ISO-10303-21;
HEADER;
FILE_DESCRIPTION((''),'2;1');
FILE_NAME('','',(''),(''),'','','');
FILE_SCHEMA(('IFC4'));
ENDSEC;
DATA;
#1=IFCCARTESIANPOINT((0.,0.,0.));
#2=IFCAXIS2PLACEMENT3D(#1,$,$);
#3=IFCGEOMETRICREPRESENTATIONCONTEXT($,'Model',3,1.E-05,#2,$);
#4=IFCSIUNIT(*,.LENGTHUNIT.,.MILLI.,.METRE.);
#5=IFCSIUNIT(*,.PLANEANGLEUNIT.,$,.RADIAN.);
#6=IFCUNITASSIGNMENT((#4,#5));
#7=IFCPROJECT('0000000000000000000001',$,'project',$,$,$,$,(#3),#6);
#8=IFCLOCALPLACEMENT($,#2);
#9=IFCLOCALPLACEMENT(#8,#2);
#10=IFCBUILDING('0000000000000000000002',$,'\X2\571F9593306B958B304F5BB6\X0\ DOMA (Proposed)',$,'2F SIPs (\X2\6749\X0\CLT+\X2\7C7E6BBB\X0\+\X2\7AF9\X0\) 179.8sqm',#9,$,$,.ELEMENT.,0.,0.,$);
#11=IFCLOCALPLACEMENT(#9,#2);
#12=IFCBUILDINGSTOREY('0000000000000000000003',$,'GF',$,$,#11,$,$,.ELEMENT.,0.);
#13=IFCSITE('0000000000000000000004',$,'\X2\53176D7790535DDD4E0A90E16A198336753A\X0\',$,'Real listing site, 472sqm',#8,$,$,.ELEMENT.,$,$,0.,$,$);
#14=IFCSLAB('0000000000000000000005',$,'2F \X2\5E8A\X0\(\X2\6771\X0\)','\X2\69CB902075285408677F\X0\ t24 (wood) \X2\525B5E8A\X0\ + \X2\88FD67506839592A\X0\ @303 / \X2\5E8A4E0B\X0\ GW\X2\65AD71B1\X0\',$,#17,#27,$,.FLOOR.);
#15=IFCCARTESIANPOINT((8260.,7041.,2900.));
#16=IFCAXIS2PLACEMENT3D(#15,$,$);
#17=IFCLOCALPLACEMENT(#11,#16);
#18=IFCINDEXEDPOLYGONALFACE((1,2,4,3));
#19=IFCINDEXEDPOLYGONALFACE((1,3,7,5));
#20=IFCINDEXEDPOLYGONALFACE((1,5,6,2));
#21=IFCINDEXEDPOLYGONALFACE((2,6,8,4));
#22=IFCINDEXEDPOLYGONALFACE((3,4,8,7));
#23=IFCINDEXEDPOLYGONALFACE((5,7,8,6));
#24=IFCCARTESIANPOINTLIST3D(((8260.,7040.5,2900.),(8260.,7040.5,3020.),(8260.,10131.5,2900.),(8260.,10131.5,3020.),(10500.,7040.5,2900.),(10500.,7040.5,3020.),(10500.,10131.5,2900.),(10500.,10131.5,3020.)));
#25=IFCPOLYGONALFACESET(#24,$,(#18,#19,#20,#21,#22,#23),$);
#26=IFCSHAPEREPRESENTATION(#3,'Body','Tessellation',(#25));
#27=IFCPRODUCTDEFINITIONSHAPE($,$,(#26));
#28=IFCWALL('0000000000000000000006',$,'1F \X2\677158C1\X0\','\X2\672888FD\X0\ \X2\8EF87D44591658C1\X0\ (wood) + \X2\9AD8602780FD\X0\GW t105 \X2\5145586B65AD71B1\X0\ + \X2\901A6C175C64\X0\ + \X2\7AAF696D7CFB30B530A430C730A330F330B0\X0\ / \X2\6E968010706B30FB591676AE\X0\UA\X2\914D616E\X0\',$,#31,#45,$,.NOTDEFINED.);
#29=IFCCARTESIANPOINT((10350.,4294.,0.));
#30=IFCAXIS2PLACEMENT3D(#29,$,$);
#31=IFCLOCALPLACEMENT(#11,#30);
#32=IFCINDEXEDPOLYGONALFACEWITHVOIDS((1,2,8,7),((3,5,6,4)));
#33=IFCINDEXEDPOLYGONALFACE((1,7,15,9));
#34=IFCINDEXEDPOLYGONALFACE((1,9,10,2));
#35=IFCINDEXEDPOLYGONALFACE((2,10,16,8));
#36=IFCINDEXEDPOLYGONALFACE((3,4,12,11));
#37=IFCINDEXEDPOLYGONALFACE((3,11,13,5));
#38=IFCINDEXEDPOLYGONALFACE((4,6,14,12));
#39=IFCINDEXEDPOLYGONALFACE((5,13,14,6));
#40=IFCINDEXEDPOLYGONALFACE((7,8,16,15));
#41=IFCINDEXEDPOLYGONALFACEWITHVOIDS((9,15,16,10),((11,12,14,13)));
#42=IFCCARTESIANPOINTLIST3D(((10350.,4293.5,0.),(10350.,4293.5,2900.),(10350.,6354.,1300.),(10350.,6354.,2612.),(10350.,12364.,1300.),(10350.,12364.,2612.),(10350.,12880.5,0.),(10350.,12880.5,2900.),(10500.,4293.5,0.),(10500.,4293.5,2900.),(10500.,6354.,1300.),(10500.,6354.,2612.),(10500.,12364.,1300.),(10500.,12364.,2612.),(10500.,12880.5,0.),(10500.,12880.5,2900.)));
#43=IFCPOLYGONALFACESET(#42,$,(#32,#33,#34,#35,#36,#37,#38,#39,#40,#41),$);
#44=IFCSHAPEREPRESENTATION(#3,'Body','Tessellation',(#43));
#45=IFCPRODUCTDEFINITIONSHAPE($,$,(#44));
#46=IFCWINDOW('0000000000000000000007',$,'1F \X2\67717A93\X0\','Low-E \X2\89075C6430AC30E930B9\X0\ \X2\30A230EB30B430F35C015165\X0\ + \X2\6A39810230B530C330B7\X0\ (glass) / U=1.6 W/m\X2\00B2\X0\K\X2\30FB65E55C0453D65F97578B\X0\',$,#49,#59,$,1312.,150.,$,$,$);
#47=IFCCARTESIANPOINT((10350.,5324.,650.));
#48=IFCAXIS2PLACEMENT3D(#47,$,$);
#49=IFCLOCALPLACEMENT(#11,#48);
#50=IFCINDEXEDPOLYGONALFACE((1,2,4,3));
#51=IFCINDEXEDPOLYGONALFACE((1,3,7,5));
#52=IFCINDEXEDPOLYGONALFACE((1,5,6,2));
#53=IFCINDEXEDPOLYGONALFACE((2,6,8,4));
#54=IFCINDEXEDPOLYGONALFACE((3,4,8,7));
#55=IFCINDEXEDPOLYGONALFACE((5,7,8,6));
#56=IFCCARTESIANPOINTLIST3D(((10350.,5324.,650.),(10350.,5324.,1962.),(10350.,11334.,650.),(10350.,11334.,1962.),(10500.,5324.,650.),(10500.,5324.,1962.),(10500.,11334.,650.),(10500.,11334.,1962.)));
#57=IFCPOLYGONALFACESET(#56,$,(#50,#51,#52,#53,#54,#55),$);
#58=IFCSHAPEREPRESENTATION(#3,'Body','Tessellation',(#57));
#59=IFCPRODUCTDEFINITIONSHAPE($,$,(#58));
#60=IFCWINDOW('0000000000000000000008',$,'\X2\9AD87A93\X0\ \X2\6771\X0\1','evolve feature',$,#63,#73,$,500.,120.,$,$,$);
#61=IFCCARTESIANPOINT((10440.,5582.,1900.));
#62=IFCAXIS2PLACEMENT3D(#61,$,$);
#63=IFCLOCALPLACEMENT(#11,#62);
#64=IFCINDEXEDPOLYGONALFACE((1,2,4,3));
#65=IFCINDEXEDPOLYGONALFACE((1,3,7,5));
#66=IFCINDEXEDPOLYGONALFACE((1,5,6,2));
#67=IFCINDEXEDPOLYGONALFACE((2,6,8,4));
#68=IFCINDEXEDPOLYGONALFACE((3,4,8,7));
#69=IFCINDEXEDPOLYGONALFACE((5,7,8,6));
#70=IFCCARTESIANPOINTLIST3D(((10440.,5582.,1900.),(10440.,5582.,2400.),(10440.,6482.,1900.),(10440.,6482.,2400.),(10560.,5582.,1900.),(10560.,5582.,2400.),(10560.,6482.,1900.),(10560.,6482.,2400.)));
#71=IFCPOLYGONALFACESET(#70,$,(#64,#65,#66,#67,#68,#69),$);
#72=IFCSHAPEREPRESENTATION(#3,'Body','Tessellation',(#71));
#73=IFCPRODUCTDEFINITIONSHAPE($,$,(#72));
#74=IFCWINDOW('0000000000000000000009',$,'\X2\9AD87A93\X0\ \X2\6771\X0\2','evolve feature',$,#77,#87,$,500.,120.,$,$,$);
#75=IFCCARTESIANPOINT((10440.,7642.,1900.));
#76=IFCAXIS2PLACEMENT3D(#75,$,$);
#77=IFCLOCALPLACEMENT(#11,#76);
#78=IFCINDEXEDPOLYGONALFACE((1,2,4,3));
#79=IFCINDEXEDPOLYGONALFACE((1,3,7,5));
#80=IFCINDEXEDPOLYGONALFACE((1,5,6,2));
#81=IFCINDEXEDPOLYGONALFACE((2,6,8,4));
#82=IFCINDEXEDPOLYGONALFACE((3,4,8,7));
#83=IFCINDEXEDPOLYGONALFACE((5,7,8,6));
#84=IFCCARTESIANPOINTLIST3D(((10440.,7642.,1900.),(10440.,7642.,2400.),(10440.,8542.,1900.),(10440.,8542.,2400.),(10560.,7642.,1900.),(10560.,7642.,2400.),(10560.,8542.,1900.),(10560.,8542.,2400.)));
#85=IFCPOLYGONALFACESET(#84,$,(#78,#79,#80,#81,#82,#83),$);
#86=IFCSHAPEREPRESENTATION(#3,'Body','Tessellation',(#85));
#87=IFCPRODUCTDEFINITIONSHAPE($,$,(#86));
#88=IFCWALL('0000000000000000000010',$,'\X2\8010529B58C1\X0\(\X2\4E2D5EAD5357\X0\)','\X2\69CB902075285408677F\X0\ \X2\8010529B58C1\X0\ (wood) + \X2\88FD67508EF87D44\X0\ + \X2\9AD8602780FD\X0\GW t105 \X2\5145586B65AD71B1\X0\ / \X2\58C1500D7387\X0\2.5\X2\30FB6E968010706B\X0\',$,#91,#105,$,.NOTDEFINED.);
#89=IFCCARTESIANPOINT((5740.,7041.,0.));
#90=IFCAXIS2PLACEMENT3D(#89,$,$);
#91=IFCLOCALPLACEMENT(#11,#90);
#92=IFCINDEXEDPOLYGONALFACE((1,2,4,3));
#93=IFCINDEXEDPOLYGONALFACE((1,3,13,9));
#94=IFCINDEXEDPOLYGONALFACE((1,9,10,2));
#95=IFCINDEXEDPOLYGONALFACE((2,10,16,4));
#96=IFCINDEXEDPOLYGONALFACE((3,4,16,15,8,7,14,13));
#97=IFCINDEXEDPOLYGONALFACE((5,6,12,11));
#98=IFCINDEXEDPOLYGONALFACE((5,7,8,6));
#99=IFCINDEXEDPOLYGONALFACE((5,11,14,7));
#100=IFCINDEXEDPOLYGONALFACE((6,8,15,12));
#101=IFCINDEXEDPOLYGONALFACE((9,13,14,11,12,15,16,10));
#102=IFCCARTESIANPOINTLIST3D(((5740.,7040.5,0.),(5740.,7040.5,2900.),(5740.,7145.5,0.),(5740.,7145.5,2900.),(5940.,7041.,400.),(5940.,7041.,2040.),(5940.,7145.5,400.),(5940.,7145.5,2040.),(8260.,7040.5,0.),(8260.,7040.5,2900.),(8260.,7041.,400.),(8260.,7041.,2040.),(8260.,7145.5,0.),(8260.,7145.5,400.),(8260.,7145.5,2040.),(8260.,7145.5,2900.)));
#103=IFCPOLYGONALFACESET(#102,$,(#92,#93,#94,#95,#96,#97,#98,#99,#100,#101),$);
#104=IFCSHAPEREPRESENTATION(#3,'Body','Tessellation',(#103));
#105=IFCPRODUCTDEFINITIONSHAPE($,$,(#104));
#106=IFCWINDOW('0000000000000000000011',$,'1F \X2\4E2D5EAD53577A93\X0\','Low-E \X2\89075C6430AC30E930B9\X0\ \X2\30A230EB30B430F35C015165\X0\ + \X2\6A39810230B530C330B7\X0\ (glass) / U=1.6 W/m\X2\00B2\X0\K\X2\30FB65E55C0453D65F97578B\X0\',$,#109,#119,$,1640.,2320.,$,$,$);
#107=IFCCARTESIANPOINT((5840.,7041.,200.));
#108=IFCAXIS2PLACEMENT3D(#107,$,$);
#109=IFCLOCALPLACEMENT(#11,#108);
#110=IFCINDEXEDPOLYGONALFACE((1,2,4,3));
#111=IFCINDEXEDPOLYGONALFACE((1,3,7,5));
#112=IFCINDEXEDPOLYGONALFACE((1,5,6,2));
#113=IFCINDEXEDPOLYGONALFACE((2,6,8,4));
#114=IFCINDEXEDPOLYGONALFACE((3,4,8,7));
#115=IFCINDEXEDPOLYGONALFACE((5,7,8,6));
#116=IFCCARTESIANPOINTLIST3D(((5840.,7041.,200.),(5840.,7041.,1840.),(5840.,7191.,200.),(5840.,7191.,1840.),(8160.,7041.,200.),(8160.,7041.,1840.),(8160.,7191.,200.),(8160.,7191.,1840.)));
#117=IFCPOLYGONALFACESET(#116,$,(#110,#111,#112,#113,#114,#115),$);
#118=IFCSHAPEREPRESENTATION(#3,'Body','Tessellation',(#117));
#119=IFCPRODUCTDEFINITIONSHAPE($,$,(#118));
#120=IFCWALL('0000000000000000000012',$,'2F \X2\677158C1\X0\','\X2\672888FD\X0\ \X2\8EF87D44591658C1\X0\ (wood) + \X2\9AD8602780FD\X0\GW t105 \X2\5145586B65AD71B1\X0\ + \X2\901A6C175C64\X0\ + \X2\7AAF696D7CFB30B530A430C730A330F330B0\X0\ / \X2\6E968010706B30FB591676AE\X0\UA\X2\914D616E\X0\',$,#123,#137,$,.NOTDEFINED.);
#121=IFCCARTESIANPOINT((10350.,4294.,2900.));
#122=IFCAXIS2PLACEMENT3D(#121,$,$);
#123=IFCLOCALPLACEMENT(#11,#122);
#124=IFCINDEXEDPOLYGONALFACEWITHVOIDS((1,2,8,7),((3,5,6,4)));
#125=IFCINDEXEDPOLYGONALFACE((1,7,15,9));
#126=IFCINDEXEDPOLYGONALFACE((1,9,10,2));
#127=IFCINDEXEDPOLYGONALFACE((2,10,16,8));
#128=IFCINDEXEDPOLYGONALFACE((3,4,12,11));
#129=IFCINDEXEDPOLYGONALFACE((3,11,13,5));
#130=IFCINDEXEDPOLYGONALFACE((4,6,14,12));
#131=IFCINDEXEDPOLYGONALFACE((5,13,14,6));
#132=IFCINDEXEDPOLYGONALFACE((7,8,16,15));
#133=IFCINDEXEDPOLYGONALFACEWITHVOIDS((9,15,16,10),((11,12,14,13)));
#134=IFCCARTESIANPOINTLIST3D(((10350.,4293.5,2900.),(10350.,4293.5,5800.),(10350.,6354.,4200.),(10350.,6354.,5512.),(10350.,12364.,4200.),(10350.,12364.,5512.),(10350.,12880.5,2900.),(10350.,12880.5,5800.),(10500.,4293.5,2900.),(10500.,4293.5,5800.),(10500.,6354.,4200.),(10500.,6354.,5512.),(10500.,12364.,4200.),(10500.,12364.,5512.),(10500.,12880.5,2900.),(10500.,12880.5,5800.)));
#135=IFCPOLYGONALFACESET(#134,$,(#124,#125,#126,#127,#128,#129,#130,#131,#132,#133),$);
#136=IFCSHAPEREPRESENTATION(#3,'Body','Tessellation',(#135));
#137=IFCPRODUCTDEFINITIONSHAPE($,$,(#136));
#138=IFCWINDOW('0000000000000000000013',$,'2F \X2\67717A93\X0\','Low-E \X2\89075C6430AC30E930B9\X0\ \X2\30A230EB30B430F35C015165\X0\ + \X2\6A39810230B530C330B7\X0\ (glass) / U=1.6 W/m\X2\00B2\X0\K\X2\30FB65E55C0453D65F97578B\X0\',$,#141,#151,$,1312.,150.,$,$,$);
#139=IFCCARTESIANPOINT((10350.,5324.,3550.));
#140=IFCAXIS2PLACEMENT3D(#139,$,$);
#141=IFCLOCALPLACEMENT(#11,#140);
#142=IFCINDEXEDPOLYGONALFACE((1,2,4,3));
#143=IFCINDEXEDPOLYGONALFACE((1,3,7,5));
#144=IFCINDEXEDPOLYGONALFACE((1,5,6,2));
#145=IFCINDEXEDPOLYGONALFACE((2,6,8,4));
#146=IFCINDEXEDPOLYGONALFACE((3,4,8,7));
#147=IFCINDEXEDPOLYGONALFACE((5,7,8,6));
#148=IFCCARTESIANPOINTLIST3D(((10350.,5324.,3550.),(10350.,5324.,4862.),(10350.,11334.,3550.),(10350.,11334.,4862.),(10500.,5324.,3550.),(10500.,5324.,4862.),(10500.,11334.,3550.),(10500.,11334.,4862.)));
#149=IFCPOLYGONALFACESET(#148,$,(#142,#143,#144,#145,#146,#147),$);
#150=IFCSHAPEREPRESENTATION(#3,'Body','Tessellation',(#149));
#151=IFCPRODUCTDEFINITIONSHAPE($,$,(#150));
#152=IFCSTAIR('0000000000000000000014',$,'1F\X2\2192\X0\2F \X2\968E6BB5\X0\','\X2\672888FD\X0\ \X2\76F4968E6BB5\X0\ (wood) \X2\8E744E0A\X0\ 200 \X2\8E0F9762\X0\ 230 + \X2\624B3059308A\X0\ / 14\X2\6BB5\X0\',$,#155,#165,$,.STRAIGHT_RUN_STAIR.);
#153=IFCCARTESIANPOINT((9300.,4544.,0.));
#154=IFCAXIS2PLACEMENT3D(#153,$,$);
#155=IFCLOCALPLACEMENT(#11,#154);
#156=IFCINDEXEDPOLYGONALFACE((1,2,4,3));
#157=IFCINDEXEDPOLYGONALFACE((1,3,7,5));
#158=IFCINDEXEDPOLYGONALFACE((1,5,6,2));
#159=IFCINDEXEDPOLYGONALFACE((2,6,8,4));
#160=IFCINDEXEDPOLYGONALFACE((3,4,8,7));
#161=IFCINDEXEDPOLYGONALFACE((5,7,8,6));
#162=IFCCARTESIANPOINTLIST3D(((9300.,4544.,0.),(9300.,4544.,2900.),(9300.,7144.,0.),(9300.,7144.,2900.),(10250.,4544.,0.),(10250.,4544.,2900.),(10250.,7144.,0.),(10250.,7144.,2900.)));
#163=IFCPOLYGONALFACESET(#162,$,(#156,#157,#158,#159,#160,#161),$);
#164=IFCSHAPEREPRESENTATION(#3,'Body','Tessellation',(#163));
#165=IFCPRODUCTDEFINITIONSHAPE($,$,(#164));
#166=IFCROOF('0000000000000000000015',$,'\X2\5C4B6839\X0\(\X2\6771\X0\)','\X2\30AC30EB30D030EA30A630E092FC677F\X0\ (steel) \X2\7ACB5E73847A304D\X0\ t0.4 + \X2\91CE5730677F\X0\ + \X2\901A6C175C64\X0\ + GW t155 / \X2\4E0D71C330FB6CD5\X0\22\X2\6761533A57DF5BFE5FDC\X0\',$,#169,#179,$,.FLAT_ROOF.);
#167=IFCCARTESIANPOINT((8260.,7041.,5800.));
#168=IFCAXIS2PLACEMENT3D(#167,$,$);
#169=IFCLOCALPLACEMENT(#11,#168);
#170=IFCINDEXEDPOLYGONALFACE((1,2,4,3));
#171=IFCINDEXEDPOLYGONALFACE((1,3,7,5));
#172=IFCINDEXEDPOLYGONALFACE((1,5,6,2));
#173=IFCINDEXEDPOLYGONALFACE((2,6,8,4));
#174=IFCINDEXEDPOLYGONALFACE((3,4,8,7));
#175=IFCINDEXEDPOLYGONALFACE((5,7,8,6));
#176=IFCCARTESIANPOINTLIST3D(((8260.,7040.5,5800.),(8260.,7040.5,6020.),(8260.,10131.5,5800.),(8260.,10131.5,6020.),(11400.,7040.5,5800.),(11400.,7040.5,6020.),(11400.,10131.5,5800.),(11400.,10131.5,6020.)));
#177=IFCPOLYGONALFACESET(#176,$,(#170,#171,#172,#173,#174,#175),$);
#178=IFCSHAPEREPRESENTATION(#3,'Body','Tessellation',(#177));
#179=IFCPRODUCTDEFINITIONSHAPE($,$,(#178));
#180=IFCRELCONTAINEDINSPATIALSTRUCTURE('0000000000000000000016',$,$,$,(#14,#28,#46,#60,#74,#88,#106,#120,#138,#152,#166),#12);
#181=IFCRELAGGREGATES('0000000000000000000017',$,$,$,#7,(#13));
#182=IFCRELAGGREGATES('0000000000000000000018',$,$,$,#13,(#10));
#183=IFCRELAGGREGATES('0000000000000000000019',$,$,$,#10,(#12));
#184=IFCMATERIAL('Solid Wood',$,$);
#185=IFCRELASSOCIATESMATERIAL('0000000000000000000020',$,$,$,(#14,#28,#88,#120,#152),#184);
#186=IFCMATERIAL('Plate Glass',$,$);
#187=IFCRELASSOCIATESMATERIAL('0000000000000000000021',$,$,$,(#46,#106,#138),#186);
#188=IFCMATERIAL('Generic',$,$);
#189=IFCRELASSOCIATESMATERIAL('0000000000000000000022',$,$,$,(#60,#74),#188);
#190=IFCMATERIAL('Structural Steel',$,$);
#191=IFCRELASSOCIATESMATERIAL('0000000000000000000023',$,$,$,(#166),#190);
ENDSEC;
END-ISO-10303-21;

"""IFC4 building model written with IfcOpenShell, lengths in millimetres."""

from ifc_helpers import new_model, si_unit, frame, frame_2d, origin, place, context, project, spatial, rectangle, extrude, material, element, fill, save


model = new_model("IFC4")

# Units and contexts
model_context = context("Model", 3, precision=1e-05, world=origin())
ifc_project = project(units=[si_unit("LENGTHUNIT", "METRE", prefix="MILLI"), si_unit("PLANEANGLEUNIT", "RADIAN")], contexts=[model_context])

# Site, building, storey
site_placement = place(None, origin())
site = spatial("IfcSite", under=ifc_project, at=site_placement, Name="北海道川上郡標茶町", ObjectType="Real listing site, 472sqm", CompositionType="ELEMENT", RefElevation=0.0)
building_placement = place(site_placement, origin())
building = spatial("IfcBuilding", under=site, at=building_placement, Name="土間に開く家 DOMA (Proposed)", ObjectType="2F SIPs (杉CLT+籾殻+竹) 179.8sqm", CompositionType="ELEMENT", ElevationOfRefHeight=0.0, ElevationOfTerrain=0.0)
storey_placement = place(building_placement, origin())
storey = spatial("IfcBuildingStorey", under=building, at=storey_placement, Name="GF", CompositionType="ELEMENT", Elevation=0.0)

# Slab
ifc_material_1 = material(Name="Solid Wood")
slab_1_placement = place(storey_placement, frame((8260.0, 7041.0, 2900.0)))
element("IfcSlab", 1, at=slab_1_placement, inside=storey, material=ifc_material_1, Name="2F 床(東)", Description="構造用合板 t24 (wood) 剛床 + 製材根太 @303 / 床下 GW断熱", PredefinedType="FLOOR", context=model_context, shape_type="SweptSolid", body=[
    extrude(rectangle(XDim=2240.0, YDim=3091.0, at=frame_2d((1120.0, 1545.0))), frame((8260.0, 7041.0, 2900.0)), (0.0, 0.0, 1.0), 120.0),
])

# Wall, openings, windows
wall_1_placement = place(storey_placement, frame((10350.0, 4294.0, 0.0)))
wall_1 = element("IfcWall", 2, at=wall_1_placement, inside=storey, material=ifc_material_1, Name="1F 東壁", Description="木製 軸組外壁 (wood) + 高性能GW t105 充填断熱 + 通気層 + 窯業系サイディング / 準耐火・外皮UA配慮", PredefinedType="NOTDEFINED", context=model_context, shape_type="SweptSolid", body=[
    extrude(rectangle(XDim=150.0, YDim=8587.0, at=frame_2d((75.0, 4293.0))), frame((10350.0, 4294.0, 0.0)), (0.0, 0.0, 1.0), 2900.0),
])
opening_1_placement = place(storey_placement, frame((10350.0, 5324.0, 650.0)))
opening_1 = element("IfcOpeningElement", 3, at=opening_1_placement, cuts=wall_1, PredefinedType="NOTDEFINED", context=model_context, shape_type="SweptSolid", body=[
    extrude(rectangle(XDim=150.0, YDim=6010.0, at=frame_2d((75.0, 3005.0))), frame((10350.0, 5324.0, 650.0)), (0.0, 0.0, 1.0), 1312.0),
])
opening_2_placement = place(storey_placement, frame((10440.0, 5582.0, 1900.0)))
opening_2 = element("IfcOpeningElement", 4, at=opening_2_placement, cuts=wall_1, PredefinedType="NOTDEFINED", context=model_context, shape_type="SweptSolid", body=[
    extrude(rectangle(XDim=120.0, YDim=900.0, at=frame_2d((60.0, 450.0))), frame((10440.0, 5582.0, 1900.0)), (0.0, 0.0, 1.0), 500.0),
])
opening_3_placement = place(storey_placement, frame((10440.0, 7642.0, 1900.0)))
opening_3 = element("IfcOpeningElement", 5, at=opening_3_placement, cuts=wall_1, PredefinedType="NOTDEFINED", context=model_context, shape_type="SweptSolid", body=[
    extrude(rectangle(XDim=120.0, YDim=900.0, at=frame_2d((60.0, 450.0))), frame((10440.0, 7642.0, 1900.0)), (0.0, 0.0, 1.0), 500.0),
])
ifc_material_2 = material(Name="Plate Glass")
window_1_placement = place(storey_placement, frame((10350.0, 5324.0, 650.0)))
window_1 = element("IfcWindow", 6, at=window_1_placement, inside=storey, material=ifc_material_2, Name="1F 東窓", Description="Low-E 複層ガラス アルゴン封入 + 樹脂サッシ (glass) / U=1.6 W/m²K・日射取得型", OverallHeight=1312.0, OverallWidth=150.0, context=model_context, shape_type="SweptSolid", body=[
    extrude(rectangle(XDim=150.0, YDim=6010.0, at=frame_2d((75.0, 3005.0))), frame((10350.0, 5324.0, 650.0)), (0.0, 0.0, 1.0), 1312.0),
])
fill(opening_1, window_1)
ifc_material_3 = material(Name="Generic")
window_2_placement = place(storey_placement, frame((10440.0, 5582.0, 1900.0)))
window_2 = element("IfcWindow", 7, at=window_2_placement, inside=storey, material=ifc_material_3, Name="高窓 東1", Description="evolve feature", OverallHeight=500.0, OverallWidth=120.0, context=model_context, shape_type="SweptSolid", body=[
    extrude(rectangle(XDim=120.0, YDim=900.0, at=frame_2d((60.0, 450.0))), frame((10440.0, 5582.0, 1900.0)), (0.0, 0.0, 1.0), 500.0),
])
fill(opening_2, window_2)
window_3_placement = place(storey_placement, frame((10440.0, 7642.0, 1900.0)))
window_3 = element("IfcWindow", 8, at=window_3_placement, inside=storey, material=ifc_material_3, Name="高窓 東2", Description="evolve feature", OverallHeight=500.0, OverallWidth=120.0, context=model_context, shape_type="SweptSolid", body=[
    extrude(rectangle(XDim=120.0, YDim=900.0, at=frame_2d((60.0, 450.0))), frame((10440.0, 7642.0, 1900.0)), (0.0, 0.0, 1.0), 500.0),
])
fill(opening_3, window_3)

# Wall, opening, window
wall_2_placement = place(storey_placement, frame((5740.0, 7041.0, 0.0)))
wall_2 = element("IfcWall", 9, at=wall_2_placement, inside=storey, material=ifc_material_1, Name="耐力壁(中庭南)", Description="構造用合板 耐力壁 (wood) + 製材軸組 + 高性能GW t105 充填断熱 / 壁倍率2.5・準耐火", PredefinedType="NOTDEFINED", context=model_context, shape_type="SweptSolid", body=[
    extrude(rectangle(XDim=2520.0, YDim=105.0, at=frame_2d((1260.0, 52.0))), frame((5740.0, 7041.0, 0.0)), (0.0, 0.0, 1.0), 2900.0),
])
opening_4_placement = place(storey_placement, frame((5840.0, 7041.0, 200.0)))
opening_4 = element("IfcOpeningElement", 10, at=opening_4_placement, cuts=wall_2, PredefinedType="NOTDEFINED", context=model_context, shape_type="SweptSolid", body=[
    extrude(rectangle(XDim=2320.0, YDim=150.0, at=frame_2d((1160.0, 75.0))), frame((5840.0, 7041.0, 200.0)), (0.0, 0.0, 1.0), 1640.0),
])
window_4_placement = place(storey_placement, frame((5840.0, 7041.0, 200.0)))
window_4 = element("IfcWindow", 11, at=window_4_placement, inside=storey, material=ifc_material_2, Name="1F 中庭南窓", Description="Low-E 複層ガラス アルゴン封入 + 樹脂サッシ (glass) / U=1.6 W/m²K・日射取得型", OverallHeight=1640.0, OverallWidth=2320.0, context=model_context, shape_type="SweptSolid", body=[
    extrude(rectangle(XDim=2320.0, YDim=150.0, at=frame_2d((1160.0, 75.0))), frame((5840.0, 7041.0, 200.0)), (0.0, 0.0, 1.0), 1640.0),
])
fill(opening_4, window_4)

# Wall, opening, window
wall_3_placement = place(storey_placement, frame((10350.0, 4294.0, 2900.0)))
wall_3 = element("IfcWall", 12, at=wall_3_placement, inside=storey, material=ifc_material_1, Name="2F 東壁", Description="木製 軸組外壁 (wood) + 高性能GW t105 充填断熱 + 通気層 + 窯業系サイディング / 準耐火・外皮UA配慮", PredefinedType="NOTDEFINED", context=model_context, shape_type="SweptSolid", body=[
    extrude(rectangle(XDim=150.0, YDim=8587.0, at=frame_2d((75.0, 4293.0))), frame((10350.0, 4294.0, 2900.0)), (0.0, 0.0, 1.0), 2900.0),
])
opening_5_placement = place(storey_placement, frame((10350.0, 5324.0, 3550.0)))
opening_5 = element("IfcOpeningElement", 13, at=opening_5_placement, cuts=wall_3, PredefinedType="NOTDEFINED", context=model_context, shape_type="SweptSolid", body=[
    extrude(rectangle(XDim=150.0, YDim=6010.0, at=frame_2d((75.0, 3005.0))), frame((10350.0, 5324.0, 3550.0)), (0.0, 0.0, 1.0), 1312.0),
])
window_5_placement = place(storey_placement, frame((10350.0, 5324.0, 3550.0)))
window_5 = element("IfcWindow", 14, at=window_5_placement, inside=storey, material=ifc_material_2, Name="2F 東窓", Description="Low-E 複層ガラス アルゴン封入 + 樹脂サッシ (glass) / U=1.6 W/m²K・日射取得型", OverallHeight=1312.0, OverallWidth=150.0, context=model_context, shape_type="SweptSolid", body=[
    extrude(rectangle(XDim=150.0, YDim=6010.0, at=frame_2d((75.0, 3005.0))), frame((10350.0, 5324.0, 3550.0)), (0.0, 0.0, 1.0), 1312.0),
])
fill(opening_5, window_5)

# Stair
stair_placement = place(storey_placement, frame((9300.0, 4544.0, 0.0)))
element("IfcStair", 15, at=stair_placement, inside=storey, material=ifc_material_1, Name="1F→2F 階段", Description="木製 直階段 (wood) 蹴上 200 踏面 230 + 手すり / 14段", PredefinedType="STRAIGHT_RUN_STAIR", context=model_context, shape_type="SweptSolid", body=[
    extrude(rectangle(XDim=950.0, YDim=2600.0, at=frame_2d((475.0, 1300.0))), frame((9300.0, 4544.0, 0.0)), (0.0, 0.0, 1.0), 2900.0),
])

# Roof
ifc_material_4 = material(Name="Structural Steel")
roof_placement = place(storey_placement, frame((8260.0, 7041.0, 5800.0)))
element("IfcRoof", 16, at=roof_placement, inside=storey, material=ifc_material_4, Name="屋根(東)", Description="ガルバリウム鋼板 (steel) 立平葺き t0.4 + 野地板 + 通気層 + GW t155 / 不燃・法22条区域対応", PredefinedType="FLAT_ROOF", context=model_context, shape_type="SweptSolid", body=[
    extrude(rectangle(XDim=3140.0, YDim=3091.0, at=frame_2d((1570.0, 1545.0))), frame((8260.0, 7041.0, 5800.0)), (0.0, 0.0, 1.0), 220.0),
])

save(model, "model.ifc")
